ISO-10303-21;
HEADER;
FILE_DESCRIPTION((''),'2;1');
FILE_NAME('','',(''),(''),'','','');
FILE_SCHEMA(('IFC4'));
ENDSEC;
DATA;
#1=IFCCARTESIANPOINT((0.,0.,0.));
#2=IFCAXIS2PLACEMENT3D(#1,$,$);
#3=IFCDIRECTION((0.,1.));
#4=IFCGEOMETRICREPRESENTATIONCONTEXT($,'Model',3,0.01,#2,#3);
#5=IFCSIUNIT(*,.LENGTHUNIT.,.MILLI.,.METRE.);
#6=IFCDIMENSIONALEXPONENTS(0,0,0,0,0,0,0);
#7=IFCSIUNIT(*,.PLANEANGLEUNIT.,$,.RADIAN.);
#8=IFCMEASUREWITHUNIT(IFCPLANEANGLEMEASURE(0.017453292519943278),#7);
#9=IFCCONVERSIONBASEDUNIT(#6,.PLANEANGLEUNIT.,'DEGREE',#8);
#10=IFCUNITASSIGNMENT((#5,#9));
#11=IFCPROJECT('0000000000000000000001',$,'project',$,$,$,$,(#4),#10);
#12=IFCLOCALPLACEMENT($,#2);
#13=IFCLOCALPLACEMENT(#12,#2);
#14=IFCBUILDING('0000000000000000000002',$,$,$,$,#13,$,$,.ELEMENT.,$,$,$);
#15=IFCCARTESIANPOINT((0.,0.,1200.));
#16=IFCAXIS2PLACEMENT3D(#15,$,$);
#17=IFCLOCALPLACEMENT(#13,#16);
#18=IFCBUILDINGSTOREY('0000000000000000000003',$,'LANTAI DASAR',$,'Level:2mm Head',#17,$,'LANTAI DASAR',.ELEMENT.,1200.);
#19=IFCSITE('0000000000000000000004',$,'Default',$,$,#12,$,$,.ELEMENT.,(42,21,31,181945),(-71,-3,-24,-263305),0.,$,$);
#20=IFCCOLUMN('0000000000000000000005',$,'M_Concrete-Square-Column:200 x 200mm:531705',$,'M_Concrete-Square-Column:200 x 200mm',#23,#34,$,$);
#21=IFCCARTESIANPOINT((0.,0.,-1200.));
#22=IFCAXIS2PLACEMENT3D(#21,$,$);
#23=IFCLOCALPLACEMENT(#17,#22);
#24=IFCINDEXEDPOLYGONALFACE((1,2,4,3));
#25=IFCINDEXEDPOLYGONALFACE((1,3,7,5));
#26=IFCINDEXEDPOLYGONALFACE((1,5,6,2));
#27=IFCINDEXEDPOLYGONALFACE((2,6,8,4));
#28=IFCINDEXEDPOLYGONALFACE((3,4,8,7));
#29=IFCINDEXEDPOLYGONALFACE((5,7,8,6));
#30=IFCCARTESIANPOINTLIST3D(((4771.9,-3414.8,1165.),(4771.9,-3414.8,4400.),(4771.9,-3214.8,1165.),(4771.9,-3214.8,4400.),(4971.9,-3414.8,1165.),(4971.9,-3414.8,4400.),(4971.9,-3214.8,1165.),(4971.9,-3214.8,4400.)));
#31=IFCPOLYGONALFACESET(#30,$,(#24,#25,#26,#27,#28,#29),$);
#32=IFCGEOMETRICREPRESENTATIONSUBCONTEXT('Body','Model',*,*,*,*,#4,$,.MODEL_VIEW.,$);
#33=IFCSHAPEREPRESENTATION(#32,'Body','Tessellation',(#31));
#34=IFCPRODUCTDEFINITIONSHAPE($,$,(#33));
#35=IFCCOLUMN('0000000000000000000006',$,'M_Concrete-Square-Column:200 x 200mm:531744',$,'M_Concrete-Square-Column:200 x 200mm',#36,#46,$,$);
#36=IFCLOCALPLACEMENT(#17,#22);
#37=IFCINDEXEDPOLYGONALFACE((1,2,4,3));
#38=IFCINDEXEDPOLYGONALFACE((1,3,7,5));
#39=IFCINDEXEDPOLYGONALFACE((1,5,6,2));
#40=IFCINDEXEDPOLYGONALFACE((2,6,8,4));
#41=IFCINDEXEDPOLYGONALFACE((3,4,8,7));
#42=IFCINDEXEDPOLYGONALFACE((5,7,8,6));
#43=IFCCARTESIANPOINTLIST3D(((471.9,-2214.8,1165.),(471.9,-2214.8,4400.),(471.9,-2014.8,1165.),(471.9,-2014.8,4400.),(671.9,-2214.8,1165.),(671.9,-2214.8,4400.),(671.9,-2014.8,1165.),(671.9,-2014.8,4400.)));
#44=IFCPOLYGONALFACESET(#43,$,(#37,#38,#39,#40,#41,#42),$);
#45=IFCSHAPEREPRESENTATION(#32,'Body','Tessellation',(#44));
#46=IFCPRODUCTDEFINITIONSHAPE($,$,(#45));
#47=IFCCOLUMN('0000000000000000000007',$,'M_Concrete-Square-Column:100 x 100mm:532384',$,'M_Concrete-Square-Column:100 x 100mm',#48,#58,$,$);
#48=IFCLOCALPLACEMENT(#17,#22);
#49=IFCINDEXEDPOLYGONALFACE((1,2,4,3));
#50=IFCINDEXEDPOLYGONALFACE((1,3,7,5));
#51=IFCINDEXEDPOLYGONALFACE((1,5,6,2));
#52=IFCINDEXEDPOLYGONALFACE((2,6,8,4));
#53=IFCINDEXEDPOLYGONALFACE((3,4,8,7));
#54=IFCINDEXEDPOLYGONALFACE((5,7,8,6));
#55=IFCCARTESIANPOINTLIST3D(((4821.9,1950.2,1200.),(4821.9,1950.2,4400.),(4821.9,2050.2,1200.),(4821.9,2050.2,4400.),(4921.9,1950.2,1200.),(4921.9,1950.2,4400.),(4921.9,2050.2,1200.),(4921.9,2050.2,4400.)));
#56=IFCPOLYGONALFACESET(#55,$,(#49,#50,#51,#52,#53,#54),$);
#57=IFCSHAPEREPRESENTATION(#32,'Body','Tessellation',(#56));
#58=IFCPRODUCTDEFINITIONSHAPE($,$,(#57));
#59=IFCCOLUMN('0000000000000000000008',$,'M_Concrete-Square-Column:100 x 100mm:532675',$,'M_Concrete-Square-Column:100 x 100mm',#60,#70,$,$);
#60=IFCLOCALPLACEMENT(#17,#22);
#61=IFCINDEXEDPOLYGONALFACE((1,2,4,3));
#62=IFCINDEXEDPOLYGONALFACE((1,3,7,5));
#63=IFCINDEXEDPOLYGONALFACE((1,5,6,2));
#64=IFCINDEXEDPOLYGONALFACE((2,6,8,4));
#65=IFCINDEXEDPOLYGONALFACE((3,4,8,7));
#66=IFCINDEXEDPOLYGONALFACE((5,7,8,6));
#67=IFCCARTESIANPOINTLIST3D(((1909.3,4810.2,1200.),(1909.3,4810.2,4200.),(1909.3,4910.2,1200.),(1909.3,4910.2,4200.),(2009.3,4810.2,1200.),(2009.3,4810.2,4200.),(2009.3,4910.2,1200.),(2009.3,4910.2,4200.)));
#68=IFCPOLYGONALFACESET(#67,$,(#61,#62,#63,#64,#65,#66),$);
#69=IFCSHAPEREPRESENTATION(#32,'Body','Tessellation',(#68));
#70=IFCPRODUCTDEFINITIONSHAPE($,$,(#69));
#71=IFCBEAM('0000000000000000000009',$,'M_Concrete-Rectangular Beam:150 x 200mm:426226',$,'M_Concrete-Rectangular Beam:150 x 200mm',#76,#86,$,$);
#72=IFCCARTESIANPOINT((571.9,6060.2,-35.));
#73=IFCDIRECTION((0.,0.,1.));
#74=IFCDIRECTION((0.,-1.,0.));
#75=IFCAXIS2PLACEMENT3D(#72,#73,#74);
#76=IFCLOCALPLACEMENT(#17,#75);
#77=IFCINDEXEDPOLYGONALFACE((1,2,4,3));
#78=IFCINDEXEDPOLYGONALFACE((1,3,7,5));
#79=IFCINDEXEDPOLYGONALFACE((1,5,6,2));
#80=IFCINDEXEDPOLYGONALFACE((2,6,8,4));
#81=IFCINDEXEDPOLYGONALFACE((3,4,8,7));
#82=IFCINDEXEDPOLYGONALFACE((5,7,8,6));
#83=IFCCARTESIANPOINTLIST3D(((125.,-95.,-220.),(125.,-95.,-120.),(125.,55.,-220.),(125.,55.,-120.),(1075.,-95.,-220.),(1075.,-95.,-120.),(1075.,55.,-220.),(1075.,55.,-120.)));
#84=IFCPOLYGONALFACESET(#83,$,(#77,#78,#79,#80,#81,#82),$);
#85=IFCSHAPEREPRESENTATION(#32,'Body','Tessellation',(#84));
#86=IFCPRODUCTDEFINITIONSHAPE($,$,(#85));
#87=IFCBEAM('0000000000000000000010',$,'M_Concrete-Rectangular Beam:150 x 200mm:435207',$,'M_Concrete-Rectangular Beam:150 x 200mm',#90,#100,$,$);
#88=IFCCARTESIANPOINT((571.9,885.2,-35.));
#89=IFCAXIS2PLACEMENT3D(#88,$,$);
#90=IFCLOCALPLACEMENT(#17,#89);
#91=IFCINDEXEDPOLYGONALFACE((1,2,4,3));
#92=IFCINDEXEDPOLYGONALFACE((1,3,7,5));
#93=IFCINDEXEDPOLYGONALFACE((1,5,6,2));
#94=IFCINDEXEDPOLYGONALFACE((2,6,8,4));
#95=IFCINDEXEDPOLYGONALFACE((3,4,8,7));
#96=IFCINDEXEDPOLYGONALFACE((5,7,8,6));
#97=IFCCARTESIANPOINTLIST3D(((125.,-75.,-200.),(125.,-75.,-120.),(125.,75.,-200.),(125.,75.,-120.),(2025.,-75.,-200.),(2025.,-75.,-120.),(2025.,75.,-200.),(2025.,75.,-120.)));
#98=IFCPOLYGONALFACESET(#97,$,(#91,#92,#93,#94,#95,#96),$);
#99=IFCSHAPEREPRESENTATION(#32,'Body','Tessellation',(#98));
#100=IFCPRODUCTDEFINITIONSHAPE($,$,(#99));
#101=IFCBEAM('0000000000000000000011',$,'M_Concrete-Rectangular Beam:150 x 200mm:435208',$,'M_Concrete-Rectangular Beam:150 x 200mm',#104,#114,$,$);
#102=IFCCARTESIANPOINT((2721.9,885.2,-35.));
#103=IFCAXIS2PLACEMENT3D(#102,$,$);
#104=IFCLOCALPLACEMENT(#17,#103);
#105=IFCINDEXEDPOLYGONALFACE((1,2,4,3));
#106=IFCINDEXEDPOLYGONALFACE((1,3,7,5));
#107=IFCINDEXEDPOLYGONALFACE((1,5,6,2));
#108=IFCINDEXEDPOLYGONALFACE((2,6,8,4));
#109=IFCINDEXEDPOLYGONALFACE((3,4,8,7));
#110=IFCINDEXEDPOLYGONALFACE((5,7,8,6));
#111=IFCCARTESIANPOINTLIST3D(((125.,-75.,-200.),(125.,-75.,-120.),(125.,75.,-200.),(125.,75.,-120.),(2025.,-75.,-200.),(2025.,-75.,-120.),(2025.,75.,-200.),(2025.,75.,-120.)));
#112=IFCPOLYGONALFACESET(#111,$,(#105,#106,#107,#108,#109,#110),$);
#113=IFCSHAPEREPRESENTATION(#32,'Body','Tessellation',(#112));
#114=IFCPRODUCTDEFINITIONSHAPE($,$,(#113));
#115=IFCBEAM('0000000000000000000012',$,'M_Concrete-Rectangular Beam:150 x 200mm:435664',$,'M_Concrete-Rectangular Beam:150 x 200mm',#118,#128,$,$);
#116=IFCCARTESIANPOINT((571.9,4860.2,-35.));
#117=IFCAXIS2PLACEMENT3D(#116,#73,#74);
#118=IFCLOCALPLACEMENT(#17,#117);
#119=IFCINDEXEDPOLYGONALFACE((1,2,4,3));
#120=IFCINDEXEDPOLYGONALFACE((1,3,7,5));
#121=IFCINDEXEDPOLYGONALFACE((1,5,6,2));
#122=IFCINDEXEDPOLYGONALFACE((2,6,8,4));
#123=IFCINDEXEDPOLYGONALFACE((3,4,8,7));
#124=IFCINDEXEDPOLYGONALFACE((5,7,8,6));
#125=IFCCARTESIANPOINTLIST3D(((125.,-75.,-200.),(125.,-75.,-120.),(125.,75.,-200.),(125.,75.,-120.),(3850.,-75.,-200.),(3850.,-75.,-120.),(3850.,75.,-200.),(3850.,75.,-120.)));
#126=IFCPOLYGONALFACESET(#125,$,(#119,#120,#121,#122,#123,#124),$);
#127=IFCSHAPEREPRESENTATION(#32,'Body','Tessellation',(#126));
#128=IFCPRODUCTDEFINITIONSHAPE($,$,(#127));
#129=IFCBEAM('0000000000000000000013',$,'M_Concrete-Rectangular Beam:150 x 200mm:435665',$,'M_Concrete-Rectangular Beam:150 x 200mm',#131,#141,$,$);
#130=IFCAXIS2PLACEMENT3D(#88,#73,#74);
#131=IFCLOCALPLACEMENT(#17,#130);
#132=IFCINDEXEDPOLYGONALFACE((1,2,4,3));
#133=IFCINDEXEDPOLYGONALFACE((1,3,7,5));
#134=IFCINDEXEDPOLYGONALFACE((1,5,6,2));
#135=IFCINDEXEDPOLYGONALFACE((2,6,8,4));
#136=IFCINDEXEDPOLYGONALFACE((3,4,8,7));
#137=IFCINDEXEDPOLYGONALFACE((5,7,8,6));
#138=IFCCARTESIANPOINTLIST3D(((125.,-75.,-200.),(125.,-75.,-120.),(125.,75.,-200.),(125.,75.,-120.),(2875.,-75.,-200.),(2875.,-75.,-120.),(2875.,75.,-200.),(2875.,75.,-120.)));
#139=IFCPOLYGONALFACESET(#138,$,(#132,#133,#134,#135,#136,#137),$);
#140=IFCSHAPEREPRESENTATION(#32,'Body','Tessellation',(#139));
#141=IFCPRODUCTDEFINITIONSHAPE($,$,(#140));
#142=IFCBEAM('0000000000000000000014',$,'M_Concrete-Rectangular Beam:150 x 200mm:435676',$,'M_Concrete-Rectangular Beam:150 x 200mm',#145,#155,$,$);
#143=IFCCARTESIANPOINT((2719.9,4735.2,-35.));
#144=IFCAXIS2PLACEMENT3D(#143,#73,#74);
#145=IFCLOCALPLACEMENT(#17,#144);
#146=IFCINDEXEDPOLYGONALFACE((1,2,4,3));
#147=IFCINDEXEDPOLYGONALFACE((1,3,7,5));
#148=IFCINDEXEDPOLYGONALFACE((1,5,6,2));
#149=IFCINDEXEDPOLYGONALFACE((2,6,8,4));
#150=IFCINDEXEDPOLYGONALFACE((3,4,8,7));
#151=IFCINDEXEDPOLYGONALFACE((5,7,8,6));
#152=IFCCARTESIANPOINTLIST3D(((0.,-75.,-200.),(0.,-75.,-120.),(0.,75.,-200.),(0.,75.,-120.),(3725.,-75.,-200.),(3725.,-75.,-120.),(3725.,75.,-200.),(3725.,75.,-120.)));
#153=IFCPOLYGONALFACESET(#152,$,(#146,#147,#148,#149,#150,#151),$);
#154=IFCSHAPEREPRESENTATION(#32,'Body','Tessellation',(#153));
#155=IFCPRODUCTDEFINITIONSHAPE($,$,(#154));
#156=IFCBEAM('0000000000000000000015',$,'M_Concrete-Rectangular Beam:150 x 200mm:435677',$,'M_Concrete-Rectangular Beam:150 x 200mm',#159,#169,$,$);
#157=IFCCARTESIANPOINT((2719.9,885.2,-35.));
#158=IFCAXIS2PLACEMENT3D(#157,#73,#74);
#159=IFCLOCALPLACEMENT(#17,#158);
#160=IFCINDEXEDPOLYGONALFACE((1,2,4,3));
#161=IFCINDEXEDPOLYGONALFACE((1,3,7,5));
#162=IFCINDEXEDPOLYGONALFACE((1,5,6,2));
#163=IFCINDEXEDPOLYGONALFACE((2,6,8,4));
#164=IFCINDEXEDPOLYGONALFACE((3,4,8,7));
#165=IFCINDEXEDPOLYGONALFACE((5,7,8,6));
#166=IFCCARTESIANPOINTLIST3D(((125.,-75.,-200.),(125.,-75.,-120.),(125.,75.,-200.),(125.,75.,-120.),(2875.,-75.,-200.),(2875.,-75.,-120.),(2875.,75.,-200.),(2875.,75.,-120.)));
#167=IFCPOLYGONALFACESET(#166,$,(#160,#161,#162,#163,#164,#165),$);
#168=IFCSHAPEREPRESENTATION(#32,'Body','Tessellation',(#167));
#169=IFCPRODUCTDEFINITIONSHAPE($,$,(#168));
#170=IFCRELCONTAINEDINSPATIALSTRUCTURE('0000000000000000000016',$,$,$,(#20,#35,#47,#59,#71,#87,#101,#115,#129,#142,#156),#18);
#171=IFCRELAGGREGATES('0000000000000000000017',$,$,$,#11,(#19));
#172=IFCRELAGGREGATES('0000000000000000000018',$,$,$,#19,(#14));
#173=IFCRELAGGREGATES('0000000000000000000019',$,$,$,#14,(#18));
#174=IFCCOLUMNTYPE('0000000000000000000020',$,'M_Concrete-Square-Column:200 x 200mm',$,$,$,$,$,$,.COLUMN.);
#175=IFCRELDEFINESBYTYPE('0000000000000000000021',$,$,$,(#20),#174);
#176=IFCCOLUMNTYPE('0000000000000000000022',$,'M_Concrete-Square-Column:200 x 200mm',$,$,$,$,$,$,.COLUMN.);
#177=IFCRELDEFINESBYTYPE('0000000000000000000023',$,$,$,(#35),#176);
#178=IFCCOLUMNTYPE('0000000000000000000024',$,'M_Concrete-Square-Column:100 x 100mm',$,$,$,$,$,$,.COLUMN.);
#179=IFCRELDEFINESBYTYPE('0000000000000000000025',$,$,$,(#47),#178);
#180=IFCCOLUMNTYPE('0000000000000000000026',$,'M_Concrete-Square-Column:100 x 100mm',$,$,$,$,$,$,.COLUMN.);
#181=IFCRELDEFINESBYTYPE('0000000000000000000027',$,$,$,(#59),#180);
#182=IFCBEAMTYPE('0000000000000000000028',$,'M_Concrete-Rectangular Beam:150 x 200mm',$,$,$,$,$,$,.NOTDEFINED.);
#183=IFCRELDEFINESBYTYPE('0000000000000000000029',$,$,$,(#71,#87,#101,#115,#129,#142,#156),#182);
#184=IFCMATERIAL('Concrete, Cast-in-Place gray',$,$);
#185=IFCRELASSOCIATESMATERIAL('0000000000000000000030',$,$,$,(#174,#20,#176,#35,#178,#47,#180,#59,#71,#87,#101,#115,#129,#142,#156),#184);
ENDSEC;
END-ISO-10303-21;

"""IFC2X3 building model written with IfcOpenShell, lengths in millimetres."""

from ifc_helpers import new_model, entity, si_unit, converted_unit, direction, frame, frame_2d, origin, origin_2d_with_axis, place, context, subcontext, project, spatial, rectangle, extrude, source, transform, mapped, material, type_object, type_shapes, element, save


model = new_model("IFC2X3")

# Units and contexts
model_context = context("Model", 3, precision=0.01, world=origin(), true_north=direction((0.0, 1.0)))
body_context = subcontext(model_context, "Body", "Model", "MODEL_VIEW")
ifc_project = project(units=[si_unit("LENGTHUNIT", "METRE", prefix="MILLI"), converted_unit("PLANEANGLEUNIT", "DEGREE", entity("IfcPlaneAngleMeasure", 0.017453292519943278), si_unit("PLANEANGLEUNIT", "RADIAN"), dimensions=[0, 0, 0, 0, 0, 0, 0])], contexts=[model_context])

# Site, building, storey
site_placement = place(None, origin())
site = spatial("IfcSite", under=ifc_project, at=site_placement, Name="Default", CompositionType="ELEMENT", RefLatitude=(42, 21, 31, 181945), RefLongitude=(-71, -3, -24, -263305), RefElevation=0.0)
building_placement = place(site_placement, origin())
building = spatial("IfcBuilding", under=site, at=building_placement, CompositionType="ELEMENT")
storey_placement = place(building_placement, frame((0.0, 0.0, 1200.0)))
storey = spatial("IfcBuildingStorey", under=building, at=storey_placement, Name="LANTAI DASAR", ObjectType="Level:2mm Head", LongName="LANTAI DASAR", CompositionType="ELEMENT", Elevation=1200.0)

# Columns
ifc_material = material(Name="Concrete, Cast-in-Place gray")
column_type_1 = type_object("IfcColumnType", Name="M_Concrete-Square-Column:200 x 200mm", PredefinedType="COLUMN", material=ifc_material)
shared_shape_1 = source(origin(), body_context, "Body", "SweptSolid", [
    extrude(rectangle(XDim=200.0, YDim=200.0, at=frame_2d((0.0, 0.0), x_axis=(1.0, 0.0))), frame((4871.9, -3314.8, 1165.0), z_axis=(0.0, 0.0, 1.0), x_axis=(-1.0, 0.0, 0.0)), (0.0, 0.0, 1.0), 3235.0),
])
type_shapes(column_type_1, [shared_shape_1])
column_1_placement = place(storey_placement, frame((0.0, 0.0, -1200.0)))
element("IfcColumn", 1, at=column_1_placement, inside=storey, type_object=column_type_1, material=ifc_material, Name="M_Concrete-Square-Column:200 x 200mm:531705", ObjectType="M_Concrete-Square-Column:200 x 200mm", context=body_context, shape_type="MappedRepresentation", body=[
    mapped(shared_shape_1, transform((0.0, 0.0, 0.0), scale=1.0)),
])
column_type_2 = type_object("IfcColumnType", Name="M_Concrete-Square-Column:200 x 200mm", PredefinedType="COLUMN", material=ifc_material)
shared_shape_2 = source(origin(), body_context, "Body", "SweptSolid", [
    extrude(rectangle(XDim=200.0, YDim=200.0, at=origin_2d_with_axis()), frame((571.9, -2114.8, 1165.0), z_axis=(0.0, 0.0, 1.0), x_axis=(-1.0, 0.0, 0.0)), (0.0, 0.0, 1.0), 3235.0),
])
type_shapes(column_type_2, [shared_shape_2])
column_2_placement = place(storey_placement, frame((0.0, 0.0, -1200.0)))
element("IfcColumn", 2, at=column_2_placement, inside=storey, type_object=column_type_2, material=ifc_material, Name="M_Concrete-Square-Column:200 x 200mm:531744", ObjectType="M_Concrete-Square-Column:200 x 200mm", context=body_context, shape_type="MappedRepresentation", body=[
    mapped(shared_shape_2, transform((0.0, 0.0, 0.0), scale=1.0)),
])
column_type_3 = type_object("IfcColumnType", Name="M_Concrete-Square-Column:100 x 100mm", PredefinedType="COLUMN", material=ifc_material)
shared_shape_3 = source(origin(), body_context, "Body", "SweptSolid", [
    extrude(rectangle(XDim=100.0, YDim=100.0, at=origin_2d_with_axis()), frame((4871.9, 2000.2, 1200.0), z_axis=(0.0, 0.0, 1.0), x_axis=(-1.0, 0.0, 0.0)), (0.0, 0.0, 1.0), 3200.0),
])
type_shapes(column_type_3, [shared_shape_3])
column_3_placement = place(storey_placement, frame((0.0, 0.0, -1200.0)))
element("IfcColumn", 3, at=column_3_placement, inside=storey, type_object=column_type_3, material=ifc_material, Name="M_Concrete-Square-Column:100 x 100mm:532384", ObjectType="M_Concrete-Square-Column:100 x 100mm", context=body_context, shape_type="MappedRepresentation", body=[
    mapped(shared_shape_3, transform((0.0, 0.0, 0.0), scale=1.0)),
])
column_type_4 = type_object("IfcColumnType", Name="M_Concrete-Square-Column:100 x 100mm", PredefinedType="COLUMN", material=ifc_material)
shared_shape_4 = source(origin(), body_context, "Body", "SweptSolid", [
    extrude(rectangle(XDim=100.0, YDim=100.0, at=origin_2d_with_axis()), frame((1959.3, 4860.2, 1200.0), z_axis=(0.0, 0.0, 1.0), x_axis=(-1.0, 0.0, 0.0)), (0.0, 0.0, 1.0), 3000.0),
])
type_shapes(column_type_4, [shared_shape_4])
column_4_placement = place(storey_placement, frame((0.0, 0.0, -1200.0)))
element("IfcColumn", 4, at=column_4_placement, inside=storey, type_object=column_type_4, material=ifc_material, Name="M_Concrete-Square-Column:100 x 100mm:532675", ObjectType="M_Concrete-Square-Column:100 x 100mm", context=body_context, shape_type="MappedRepresentation", body=[
    mapped(shared_shape_4, transform((0.0, 0.0, 0.0), scale=1.0)),
])

# Beams
beam_type = type_object("IfcBeamType", Name="M_Concrete-Rectangular Beam:150 x 200mm", PredefinedType="NOTDEFINED")
beam_1_placement = place(storey_placement, frame((571.9, 6060.2, -35.0), z_axis=(0.0, 0.0, 1.0), x_axis=(0.0, -1.0, 0.0)))
element("IfcBeam", 5, at=beam_1_placement, inside=storey, type_object=beam_type, material=ifc_material, Name="M_Concrete-Rectangular Beam:150 x 200mm:426226", ObjectType="M_Concrete-Rectangular Beam:150 x 200mm", context=body_context, shape_type="SweptSolid", body=[
    extrude(rectangle(XDim=100.0, YDim=150.0, at=frame_2d((0.0, 0.0), x_axis=(1.0, 0.0))), frame((125.0, -20.0, -170.0), z_axis=(1.0, 0.0, 0.0), x_axis=(0.0, 0.0, -1.0)), (0.0, 0.0, 1.0), 950.0),
])
beam_2_placement = place(storey_placement, frame((571.9, 885.2, -35.0)))
element("IfcBeam", 6, at=beam_2_placement, inside=storey, type_object=beam_type, material=ifc_material, Name="M_Concrete-Rectangular Beam:150 x 200mm:435207", ObjectType="M_Concrete-Rectangular Beam:150 x 200mm", context=body_context, shape_type="SweptSolid", body=[
    extrude(rectangle(XDim=80.0, YDim=150.0, at=frame_2d((0.0, 0.0), x_axis=(1.0, 0.0))), frame((125.0, 0.0, -160.0), z_axis=(1.0, 0.0, 0.0), x_axis=(0.0, 0.0, -1.0)), (0.0, 0.0, 1.0), 1900.0),
])
beam_3_placement = place(storey_placement, frame((2721.9, 885.2, -35.0)))
element("IfcBeam", 7, at=beam_3_placement, inside=storey, type_object=beam_type, material=ifc_material, Name="M_Concrete-Rectangular Beam:150 x 200mm:435208", ObjectType="M_Concrete-Rectangular Beam:150 x 200mm", context=body_context, shape_type="SweptSolid", body=[
    extrude(rectangle(XDim=80.0, YDim=150.0, at=frame_2d((0.0, 0.0), x_axis=(1.0, 0.0))), frame((125.0, 0.0, -160.0), z_axis=(1.0, 0.0, 0.0), x_axis=(0.0, 0.0, -1.0)), (0.0, 0.0, 1.0), 1900.0),
])
beam_4_placement = place(storey_placement, frame((571.9, 4860.2, -35.0), z_axis=(0.0, 0.0, 1.0), x_axis=(0.0, -1.0, 0.0)))
element("IfcBeam", 8, at=beam_4_placement, inside=storey, type_object=beam_type, material=ifc_material, Name="M_Concrete-Rectangular Beam:150 x 200mm:435664", ObjectType="M_Concrete-Rectangular Beam:150 x 200mm", context=body_context, shape_type="SweptSolid", body=[
    extrude(rectangle(XDim=80.0, YDim=150.0, at=frame_2d((0.0, 0.0), x_axis=(1.0, 0.0))), frame((125.0, 0.0, -160.0), z_axis=(1.0, 0.0, 0.0), x_axis=(0.0, 0.0, -1.0)), (0.0, 0.0, 1.0), 3725.0),
])
beam_5_placement = place(storey_placement, frame((571.9, 885.2, -35.0), z_axis=(0.0, 0.0, 1.0), x_axis=(0.0, -1.0, 0.0)))
element("IfcBeam", 9, at=beam_5_placement, inside=storey, type_object=beam_type, material=ifc_material, Name="M_Concrete-Rectangular Beam:150 x 200mm:435665", ObjectType="M_Concrete-Rectangular Beam:150 x 200mm", context=body_context, shape_type="SweptSolid", body=[
    extrude(rectangle(XDim=80.0, YDim=150.0, at=frame_2d((0.0, 0.0), x_axis=(1.0, 0.0))), frame((125.0, 0.0, -160.0), z_axis=(1.0, 0.0, 0.0), x_axis=(0.0, 0.0, -1.0)), (0.0, 0.0, 1.0), 2750.0),
])
beam_6_placement = place(storey_placement, frame((2719.9, 4735.2, -35.0), z_axis=(0.0, 0.0, 1.0), x_axis=(0.0, -1.0, 0.0)))
element("IfcBeam", 10, at=beam_6_placement, inside=storey, type_object=beam_type, material=ifc_material, Name="M_Concrete-Rectangular Beam:150 x 200mm:435676", ObjectType="M_Concrete-Rectangular Beam:150 x 200mm", context=body_context, shape_type="SweptSolid", body=[
    extrude(rectangle(XDim=80.0, YDim=150.0, at=frame_2d((0.0, 0.0), x_axis=(1.0, 0.0))), frame((0.0, 0.0, -160.0), z_axis=(1.0, 0.0, 0.0), x_axis=(0.0, 0.0, -1.0)), (0.0, 0.0, 1.0), 3725.0),
])
beam_7_placement = place(storey_placement, frame((2719.9, 885.2, -35.0), z_axis=(0.0, 0.0, 1.0), x_axis=(0.0, -1.0, 0.0)))
element("IfcBeam", 11, at=beam_7_placement, inside=storey, type_object=beam_type, material=ifc_material, Name="M_Concrete-Rectangular Beam:150 x 200mm:435677", ObjectType="M_Concrete-Rectangular Beam:150 x 200mm", context=body_context, shape_type="SweptSolid", body=[
    extrude(rectangle(XDim=80.0, YDim=150.0, at=frame_2d((0.0, 0.0), x_axis=(1.0, 0.0))), frame((125.0, 0.0, -160.0), z_axis=(1.0, 0.0, 0.0), x_axis=(0.0, 0.0, -1.0)), (0.0, 0.0, 1.0), 2750.0),
])

save(model, "model.ifc")
